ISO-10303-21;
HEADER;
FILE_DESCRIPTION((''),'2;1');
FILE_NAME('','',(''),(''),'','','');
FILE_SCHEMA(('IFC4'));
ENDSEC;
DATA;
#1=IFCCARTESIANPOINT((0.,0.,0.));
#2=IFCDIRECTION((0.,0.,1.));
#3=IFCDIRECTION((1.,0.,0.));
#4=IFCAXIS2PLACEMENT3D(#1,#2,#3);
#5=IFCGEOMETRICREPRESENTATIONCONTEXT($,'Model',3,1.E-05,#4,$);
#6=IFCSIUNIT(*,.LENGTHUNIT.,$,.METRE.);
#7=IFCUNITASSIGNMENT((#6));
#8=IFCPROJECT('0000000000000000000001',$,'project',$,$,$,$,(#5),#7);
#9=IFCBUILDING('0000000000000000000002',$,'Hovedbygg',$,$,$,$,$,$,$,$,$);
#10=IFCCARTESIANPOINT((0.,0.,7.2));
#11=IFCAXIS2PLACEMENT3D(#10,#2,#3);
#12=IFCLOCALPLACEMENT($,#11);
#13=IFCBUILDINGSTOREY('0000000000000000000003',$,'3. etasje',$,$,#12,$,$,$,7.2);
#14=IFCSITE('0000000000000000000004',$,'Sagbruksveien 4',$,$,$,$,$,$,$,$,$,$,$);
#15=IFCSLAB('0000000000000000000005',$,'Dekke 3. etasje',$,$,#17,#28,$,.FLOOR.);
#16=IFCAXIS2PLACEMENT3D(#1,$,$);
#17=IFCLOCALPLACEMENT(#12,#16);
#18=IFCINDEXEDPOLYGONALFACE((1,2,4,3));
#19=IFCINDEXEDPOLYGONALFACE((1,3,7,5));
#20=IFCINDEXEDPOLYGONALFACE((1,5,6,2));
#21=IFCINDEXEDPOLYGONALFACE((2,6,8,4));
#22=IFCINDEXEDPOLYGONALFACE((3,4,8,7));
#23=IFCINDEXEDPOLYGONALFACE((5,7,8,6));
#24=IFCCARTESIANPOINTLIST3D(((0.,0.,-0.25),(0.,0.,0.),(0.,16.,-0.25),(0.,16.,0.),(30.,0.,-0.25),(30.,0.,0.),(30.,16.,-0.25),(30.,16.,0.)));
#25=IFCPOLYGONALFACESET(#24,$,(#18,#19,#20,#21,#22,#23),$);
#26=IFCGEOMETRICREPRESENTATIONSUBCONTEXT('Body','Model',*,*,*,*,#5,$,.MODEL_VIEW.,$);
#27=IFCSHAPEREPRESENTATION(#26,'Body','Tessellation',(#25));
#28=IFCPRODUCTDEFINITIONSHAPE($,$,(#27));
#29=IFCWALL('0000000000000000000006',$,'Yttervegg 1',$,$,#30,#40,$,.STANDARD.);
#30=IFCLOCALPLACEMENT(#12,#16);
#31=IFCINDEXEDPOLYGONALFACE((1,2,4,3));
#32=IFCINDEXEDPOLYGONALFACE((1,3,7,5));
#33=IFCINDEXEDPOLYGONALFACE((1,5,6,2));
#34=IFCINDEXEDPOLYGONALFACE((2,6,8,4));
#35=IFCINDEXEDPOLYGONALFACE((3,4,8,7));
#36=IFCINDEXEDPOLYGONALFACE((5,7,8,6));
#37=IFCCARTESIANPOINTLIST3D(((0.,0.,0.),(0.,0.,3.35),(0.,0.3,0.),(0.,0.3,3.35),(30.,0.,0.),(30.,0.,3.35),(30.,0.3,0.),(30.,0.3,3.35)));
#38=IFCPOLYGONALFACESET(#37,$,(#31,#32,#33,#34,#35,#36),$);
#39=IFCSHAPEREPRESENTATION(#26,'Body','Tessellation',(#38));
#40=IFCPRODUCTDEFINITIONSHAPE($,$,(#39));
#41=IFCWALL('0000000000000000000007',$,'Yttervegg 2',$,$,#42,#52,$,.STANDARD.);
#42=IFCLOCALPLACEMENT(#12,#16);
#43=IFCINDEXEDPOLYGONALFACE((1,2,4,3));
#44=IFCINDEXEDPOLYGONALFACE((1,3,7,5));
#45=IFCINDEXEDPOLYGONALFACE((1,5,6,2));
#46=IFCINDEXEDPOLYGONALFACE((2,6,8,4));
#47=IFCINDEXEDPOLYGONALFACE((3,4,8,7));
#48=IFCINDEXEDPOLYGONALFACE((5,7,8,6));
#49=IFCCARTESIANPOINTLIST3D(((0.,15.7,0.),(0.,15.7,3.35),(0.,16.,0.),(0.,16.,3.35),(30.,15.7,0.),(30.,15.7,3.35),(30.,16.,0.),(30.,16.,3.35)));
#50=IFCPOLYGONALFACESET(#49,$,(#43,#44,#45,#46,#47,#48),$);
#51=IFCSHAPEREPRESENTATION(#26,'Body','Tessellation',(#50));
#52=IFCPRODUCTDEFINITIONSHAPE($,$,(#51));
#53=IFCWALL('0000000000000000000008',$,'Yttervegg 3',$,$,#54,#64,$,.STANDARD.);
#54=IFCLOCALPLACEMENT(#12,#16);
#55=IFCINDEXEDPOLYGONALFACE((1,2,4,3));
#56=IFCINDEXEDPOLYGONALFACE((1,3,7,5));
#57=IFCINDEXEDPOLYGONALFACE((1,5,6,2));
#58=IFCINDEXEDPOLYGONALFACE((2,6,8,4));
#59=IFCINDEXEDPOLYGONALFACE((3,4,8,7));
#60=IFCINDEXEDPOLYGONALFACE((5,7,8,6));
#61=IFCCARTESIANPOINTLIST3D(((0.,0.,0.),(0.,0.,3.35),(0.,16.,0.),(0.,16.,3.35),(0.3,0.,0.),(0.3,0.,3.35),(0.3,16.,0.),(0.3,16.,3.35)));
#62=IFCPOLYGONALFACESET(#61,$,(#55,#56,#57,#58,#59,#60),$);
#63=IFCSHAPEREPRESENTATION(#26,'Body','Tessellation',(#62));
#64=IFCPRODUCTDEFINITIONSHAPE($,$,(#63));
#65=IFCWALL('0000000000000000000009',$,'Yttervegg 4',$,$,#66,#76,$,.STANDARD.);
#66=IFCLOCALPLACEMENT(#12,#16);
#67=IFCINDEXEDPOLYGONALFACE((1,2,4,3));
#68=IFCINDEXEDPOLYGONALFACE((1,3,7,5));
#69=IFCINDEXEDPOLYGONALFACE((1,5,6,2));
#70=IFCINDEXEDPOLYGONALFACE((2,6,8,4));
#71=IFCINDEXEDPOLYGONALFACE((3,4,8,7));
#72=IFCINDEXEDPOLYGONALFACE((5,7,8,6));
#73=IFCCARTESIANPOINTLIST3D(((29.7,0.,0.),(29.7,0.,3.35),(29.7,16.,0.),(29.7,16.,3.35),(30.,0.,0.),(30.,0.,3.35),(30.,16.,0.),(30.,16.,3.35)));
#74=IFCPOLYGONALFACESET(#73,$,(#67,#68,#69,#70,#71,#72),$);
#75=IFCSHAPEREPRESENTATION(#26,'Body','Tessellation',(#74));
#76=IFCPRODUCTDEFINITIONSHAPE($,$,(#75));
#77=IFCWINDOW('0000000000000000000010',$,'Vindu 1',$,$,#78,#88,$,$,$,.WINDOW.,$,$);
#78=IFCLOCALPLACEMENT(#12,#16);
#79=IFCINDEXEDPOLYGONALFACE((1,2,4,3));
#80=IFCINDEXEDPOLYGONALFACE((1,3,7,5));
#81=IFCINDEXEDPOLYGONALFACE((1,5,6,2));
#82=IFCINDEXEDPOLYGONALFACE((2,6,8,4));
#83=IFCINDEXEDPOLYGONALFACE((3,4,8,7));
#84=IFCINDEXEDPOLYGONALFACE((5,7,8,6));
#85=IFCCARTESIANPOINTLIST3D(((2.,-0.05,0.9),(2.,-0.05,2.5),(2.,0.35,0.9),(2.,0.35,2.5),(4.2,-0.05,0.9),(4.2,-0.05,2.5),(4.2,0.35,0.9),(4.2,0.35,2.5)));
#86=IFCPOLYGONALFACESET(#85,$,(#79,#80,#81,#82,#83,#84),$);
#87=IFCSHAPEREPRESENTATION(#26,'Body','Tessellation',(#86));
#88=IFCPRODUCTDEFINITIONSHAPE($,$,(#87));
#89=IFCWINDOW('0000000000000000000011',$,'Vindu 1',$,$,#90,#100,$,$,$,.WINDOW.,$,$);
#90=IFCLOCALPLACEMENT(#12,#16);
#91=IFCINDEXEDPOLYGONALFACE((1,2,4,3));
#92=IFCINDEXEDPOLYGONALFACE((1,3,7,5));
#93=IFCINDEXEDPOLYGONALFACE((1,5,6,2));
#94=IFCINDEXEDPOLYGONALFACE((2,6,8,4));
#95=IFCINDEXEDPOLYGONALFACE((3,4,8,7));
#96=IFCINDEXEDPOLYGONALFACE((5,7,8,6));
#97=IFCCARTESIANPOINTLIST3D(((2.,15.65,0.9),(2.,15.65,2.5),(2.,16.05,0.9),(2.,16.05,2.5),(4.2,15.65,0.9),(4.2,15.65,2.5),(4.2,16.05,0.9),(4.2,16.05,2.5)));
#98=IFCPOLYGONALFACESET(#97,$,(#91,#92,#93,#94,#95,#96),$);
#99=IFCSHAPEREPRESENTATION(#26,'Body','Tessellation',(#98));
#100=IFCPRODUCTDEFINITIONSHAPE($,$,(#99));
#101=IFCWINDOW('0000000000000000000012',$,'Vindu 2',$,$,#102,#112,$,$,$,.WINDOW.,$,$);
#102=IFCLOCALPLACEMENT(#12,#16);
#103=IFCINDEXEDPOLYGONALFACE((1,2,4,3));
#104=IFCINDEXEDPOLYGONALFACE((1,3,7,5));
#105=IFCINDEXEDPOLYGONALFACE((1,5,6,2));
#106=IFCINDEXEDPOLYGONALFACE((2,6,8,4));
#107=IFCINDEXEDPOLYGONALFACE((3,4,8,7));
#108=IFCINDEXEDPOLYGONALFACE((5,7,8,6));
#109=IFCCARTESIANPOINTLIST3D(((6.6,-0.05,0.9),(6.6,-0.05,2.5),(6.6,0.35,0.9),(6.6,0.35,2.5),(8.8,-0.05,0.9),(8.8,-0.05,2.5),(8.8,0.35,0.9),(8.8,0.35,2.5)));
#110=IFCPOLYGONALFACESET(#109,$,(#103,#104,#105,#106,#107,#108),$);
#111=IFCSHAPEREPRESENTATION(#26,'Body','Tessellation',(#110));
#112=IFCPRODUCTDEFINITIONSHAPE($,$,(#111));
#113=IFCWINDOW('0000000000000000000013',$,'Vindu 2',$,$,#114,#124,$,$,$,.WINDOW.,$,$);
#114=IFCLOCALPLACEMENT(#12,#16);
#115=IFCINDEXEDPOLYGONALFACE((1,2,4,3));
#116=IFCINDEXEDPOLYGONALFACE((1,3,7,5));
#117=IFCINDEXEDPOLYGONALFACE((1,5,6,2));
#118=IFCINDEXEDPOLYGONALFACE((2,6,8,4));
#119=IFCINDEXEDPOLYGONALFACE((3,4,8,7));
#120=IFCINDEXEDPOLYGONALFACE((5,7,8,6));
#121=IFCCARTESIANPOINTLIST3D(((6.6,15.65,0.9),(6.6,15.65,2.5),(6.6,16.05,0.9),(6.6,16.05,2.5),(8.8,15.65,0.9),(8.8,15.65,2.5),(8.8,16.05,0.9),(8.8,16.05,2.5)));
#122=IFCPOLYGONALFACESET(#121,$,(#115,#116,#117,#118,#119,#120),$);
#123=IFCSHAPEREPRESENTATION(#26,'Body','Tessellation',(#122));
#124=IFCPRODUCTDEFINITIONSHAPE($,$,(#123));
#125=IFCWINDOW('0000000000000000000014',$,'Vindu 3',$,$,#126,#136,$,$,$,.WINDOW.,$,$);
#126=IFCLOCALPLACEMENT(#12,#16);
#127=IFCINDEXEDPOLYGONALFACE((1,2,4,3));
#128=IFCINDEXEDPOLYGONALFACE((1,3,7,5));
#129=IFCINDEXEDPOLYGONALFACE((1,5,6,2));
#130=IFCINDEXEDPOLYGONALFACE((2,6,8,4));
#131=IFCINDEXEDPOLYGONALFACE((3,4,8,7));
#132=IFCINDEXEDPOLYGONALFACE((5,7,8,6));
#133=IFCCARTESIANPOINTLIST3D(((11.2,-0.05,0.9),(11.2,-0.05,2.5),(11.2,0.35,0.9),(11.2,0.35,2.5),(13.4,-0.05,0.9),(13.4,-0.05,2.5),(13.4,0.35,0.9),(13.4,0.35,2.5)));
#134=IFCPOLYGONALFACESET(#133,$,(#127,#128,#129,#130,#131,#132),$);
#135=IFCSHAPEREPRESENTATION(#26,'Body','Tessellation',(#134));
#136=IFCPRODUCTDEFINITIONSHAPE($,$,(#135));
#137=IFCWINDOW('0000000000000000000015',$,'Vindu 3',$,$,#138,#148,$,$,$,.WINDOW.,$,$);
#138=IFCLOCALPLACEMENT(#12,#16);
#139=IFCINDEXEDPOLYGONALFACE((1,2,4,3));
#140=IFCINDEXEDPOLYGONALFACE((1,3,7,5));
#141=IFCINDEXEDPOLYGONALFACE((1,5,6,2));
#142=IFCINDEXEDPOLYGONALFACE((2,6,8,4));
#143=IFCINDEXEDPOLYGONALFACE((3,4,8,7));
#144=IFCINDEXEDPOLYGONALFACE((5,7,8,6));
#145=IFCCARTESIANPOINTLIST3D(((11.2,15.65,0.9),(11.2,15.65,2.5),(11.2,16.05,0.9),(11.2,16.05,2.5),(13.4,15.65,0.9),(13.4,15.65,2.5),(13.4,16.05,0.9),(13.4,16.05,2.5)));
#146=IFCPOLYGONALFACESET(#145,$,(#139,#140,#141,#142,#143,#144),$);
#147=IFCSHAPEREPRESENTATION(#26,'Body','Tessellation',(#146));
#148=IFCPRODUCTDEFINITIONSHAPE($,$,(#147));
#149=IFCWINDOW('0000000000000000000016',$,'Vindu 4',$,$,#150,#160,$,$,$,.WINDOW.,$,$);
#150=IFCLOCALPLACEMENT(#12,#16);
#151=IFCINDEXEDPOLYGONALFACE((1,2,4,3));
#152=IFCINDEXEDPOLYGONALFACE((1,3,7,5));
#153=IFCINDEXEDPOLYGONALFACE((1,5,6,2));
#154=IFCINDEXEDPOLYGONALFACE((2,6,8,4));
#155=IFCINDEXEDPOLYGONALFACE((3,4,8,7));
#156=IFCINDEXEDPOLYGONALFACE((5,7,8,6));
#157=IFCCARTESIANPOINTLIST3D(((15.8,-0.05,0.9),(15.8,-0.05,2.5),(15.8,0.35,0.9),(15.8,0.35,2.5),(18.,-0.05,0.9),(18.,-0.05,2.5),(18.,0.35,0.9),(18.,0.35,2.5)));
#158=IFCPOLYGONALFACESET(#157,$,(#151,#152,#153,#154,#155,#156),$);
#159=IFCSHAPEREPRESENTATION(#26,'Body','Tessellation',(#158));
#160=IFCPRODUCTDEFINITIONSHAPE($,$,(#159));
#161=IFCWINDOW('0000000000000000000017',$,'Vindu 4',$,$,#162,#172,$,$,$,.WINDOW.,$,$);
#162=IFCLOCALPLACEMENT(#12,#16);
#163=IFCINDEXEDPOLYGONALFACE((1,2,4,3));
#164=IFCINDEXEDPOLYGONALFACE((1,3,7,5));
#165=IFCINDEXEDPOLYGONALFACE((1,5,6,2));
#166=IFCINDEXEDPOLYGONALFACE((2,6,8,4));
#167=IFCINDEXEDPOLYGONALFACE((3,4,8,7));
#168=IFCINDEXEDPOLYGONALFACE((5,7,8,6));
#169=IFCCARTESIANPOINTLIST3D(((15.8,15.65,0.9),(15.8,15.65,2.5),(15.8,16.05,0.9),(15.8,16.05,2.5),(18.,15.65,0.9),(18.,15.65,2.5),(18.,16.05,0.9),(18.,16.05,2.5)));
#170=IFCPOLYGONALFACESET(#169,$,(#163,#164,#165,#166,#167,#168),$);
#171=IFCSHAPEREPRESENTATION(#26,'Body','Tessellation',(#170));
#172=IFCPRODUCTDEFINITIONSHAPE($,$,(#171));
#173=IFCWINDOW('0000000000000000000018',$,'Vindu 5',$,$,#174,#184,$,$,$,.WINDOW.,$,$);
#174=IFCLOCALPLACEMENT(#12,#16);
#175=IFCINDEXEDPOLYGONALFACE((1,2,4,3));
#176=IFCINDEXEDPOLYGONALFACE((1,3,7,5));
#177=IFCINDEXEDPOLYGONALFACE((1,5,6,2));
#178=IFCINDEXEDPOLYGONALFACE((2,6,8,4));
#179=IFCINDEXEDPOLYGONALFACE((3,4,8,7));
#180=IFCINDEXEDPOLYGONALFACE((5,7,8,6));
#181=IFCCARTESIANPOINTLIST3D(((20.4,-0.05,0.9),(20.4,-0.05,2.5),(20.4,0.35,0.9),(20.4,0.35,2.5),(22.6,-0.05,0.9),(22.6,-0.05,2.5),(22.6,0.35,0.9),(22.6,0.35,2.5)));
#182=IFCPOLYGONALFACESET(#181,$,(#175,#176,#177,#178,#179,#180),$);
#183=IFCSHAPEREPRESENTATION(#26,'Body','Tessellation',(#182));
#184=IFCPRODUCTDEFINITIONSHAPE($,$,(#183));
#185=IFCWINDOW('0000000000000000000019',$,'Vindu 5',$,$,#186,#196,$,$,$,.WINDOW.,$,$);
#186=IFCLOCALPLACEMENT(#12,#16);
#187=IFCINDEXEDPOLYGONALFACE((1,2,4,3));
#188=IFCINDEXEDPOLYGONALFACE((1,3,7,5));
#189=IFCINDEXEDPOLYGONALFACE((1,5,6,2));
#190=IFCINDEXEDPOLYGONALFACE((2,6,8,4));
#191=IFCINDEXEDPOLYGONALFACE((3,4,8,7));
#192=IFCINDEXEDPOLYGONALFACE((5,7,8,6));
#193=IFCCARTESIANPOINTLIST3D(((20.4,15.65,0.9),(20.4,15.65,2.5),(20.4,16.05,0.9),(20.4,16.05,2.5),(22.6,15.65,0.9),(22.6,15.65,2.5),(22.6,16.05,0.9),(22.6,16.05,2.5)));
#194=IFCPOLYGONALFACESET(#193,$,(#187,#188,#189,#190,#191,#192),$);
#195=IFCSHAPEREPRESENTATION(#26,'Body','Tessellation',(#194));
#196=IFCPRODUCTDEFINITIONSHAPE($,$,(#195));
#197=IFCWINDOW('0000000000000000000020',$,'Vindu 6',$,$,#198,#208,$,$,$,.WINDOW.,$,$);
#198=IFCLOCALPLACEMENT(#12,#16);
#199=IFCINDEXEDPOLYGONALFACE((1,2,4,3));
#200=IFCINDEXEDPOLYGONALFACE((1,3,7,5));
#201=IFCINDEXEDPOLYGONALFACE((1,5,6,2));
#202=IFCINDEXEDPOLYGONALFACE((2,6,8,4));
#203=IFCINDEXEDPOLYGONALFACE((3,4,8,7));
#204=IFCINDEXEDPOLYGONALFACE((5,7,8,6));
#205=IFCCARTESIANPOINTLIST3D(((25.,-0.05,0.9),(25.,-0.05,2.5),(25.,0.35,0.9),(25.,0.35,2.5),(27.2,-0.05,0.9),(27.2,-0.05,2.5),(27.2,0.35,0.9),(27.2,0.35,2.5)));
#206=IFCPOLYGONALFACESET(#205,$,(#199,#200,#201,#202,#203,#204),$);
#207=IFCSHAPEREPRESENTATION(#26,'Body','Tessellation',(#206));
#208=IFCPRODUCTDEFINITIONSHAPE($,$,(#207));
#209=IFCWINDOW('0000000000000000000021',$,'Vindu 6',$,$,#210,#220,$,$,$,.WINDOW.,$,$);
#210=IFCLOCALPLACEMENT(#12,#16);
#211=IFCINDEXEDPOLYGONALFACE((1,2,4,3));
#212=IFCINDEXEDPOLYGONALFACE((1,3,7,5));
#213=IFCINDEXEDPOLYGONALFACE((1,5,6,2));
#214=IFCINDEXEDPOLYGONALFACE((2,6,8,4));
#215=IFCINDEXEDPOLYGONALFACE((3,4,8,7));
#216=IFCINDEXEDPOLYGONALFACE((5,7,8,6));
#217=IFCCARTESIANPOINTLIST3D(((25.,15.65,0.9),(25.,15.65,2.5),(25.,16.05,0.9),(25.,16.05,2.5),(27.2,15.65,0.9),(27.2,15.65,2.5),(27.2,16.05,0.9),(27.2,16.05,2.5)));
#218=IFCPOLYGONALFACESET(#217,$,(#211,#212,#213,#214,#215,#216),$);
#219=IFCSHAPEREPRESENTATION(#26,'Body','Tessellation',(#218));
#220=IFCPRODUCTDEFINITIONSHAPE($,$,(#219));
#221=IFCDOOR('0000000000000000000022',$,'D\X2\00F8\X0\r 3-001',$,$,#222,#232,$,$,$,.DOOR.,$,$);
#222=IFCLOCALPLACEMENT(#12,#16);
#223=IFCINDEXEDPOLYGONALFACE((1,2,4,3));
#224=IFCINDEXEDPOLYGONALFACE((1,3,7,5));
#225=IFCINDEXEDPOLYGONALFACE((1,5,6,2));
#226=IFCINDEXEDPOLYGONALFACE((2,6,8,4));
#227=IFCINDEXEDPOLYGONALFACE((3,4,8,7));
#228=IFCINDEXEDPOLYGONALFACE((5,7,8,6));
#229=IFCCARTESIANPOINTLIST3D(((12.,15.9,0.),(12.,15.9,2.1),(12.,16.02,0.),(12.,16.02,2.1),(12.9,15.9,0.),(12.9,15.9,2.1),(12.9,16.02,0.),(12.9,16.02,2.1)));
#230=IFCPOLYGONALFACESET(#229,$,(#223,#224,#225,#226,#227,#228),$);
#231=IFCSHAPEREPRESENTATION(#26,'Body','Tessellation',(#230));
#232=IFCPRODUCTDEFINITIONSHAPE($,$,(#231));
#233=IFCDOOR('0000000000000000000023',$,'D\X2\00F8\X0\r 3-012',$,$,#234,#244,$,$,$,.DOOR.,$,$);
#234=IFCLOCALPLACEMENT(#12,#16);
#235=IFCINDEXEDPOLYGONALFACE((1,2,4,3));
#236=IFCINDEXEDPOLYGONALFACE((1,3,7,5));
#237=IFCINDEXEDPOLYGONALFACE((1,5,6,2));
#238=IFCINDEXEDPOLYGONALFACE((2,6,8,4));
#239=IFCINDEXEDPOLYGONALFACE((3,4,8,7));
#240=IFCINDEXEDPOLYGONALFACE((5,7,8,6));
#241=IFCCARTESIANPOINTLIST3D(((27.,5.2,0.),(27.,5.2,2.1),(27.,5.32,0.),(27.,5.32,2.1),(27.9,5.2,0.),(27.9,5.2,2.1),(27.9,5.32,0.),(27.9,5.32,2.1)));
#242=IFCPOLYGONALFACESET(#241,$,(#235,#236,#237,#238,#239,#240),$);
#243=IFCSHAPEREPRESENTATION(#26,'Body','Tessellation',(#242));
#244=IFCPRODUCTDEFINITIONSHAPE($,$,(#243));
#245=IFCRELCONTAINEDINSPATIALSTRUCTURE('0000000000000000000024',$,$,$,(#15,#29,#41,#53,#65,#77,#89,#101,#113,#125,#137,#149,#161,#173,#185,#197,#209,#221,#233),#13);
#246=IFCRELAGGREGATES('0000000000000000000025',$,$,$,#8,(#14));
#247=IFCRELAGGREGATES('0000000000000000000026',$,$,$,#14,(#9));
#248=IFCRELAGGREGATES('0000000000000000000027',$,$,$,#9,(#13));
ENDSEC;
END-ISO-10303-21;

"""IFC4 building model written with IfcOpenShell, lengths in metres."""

from ifc_helpers import new_model, si_unit, frame, origin_with_axes, place, context, subcontext, project, spatial, line, indexed_curve, outline, extrude, element, save


model = new_model("IFC4")

# Units and contexts
model_context = context("Model", 3, precision=1e-05, world=origin_with_axes())
body_context = subcontext(model_context, "Body", "Model", "MODEL_VIEW")
ifc_project = project(units=[si_unit("LENGTHUNIT", "METRE")], contexts=[model_context])

# Site, building, storey
site = spatial("IfcSite", under=ifc_project, Name="Sagbruksveien 4")
building = spatial("IfcBuilding", under=site, Name="Hovedbygg")
storey_placement = place(None, frame((0.0, 0.0, 7.2), z_axis=(0.0, 0.0, 1.0), x_axis=(1.0, 0.0, 0.0)))
storey = spatial("IfcBuildingStorey", under=building, at=storey_placement, Name="3. etasje", Elevation=7.2)

# Slab
slab_placement = place(storey_placement, frame((0.0, 0.0, -0.25), z_axis=(0.0, 0.0, 1.0), x_axis=(1.0, 0.0, 0.0)))
element("IfcSlab", 1, at=slab_placement, inside=storey, Name="Dekke 3. etasje", PredefinedType="FLOOR", context=body_context, shape_type="SweptSolid", body=[
    extrude(outline(indexed_curve([(0.0, 0.0), (30.0, 0.0), (30.0, 16.0), (0.0, 16.0)], segments=[line(1, 2, 3, 4, 1)])), origin_with_axes(), (0.0, 0.0, 1.0), 0.25),
])

# Walls
for number, where, z_axis, x_axis, name in (
    (2, (0.0, 0.0, 0.0), (0.0, 0.0, 1.0), (1.0, 0.0, 0.0), "Yttervegg 1"),
    (3, (0.0, 15.7, 0.0), (0.0, 0.0, 1.0), (1.0, 0.0, 0.0), "Yttervegg 2"),
):
    element("IfcWall", number, at=place(storey_placement, frame(where, z_axis=z_axis, x_axis=x_axis)), inside=storey, Name=name, PredefinedType="STANDARD", context=body_context, shape_type="SweptSolid", body=[
        extrude(outline(indexed_curve([(0.0, 0.0), (30.0, 0.0), (30.0, 0.3), (0.0, 0.3)], segments=[line(1, 2, 3, 4, 1)])), origin_with_axes(), (0.0, 0.0, 1.0), 3.35),
    ])
for number, where, z_axis, x_axis, name in (
    (4, (0.0, 0.0, 0.0), (0.0, 0.0, 1.0), (1.0, 0.0, 0.0), "Yttervegg 3"),
    (5, (29.7, 0.0, 0.0), (0.0, 0.0, 1.0), (1.0, 0.0, 0.0), "Yttervegg 4"),
):
    element("IfcWall", number, at=place(storey_placement, frame(where, z_axis=z_axis, x_axis=x_axis)), inside=storey, Name=name, PredefinedType="STANDARD", context=body_context, shape_type="SweptSolid", body=[
        extrude(outline(indexed_curve([(0.0, 0.0), (0.3, 0.0), (0.3, 16.0), (0.0, 16.0)], segments=[line(1, 2, 3, 4, 1)])), origin_with_axes(), (0.0, 0.0, 1.0), 3.35),
    ])

# Windows
for number, where, z_axis, x_axis, name in (
    (6, (2.0, -0.05, 0.9), (0.0, 0.0, 1.0), (1.0, 0.0, 0.0), "Vindu 1"),
    (7, (2.0, 15.65, 0.9), (0.0, 0.0, 1.0), (1.0, 0.0, 0.0), "Vindu 1"),
    (8, (6.6, -0.05, 0.9), (0.0, 0.0, 1.0), (1.0, 0.0, 0.0), "Vindu 2"),
    (9, (6.6, 15.65, 0.9), (0.0, 0.0, 1.0), (1.0, 0.0, 0.0), "Vindu 2"),
    (10, (11.2, -0.05, 0.9), (0.0, 0.0, 1.0), (1.0, 0.0, 0.0), "Vindu 3"),
    (11, (11.2, 15.65, 0.9), (0.0, 0.0, 1.0), (1.0, 0.0, 0.0), "Vindu 3"),
    (12, (15.8, -0.05, 0.9), (0.0, 0.0, 1.0), (1.0, 0.0, 0.0), "Vindu 4"),
    (13, (15.8, 15.65, 0.9), (0.0, 0.0, 1.0), (1.0, 0.0, 0.0), "Vindu 4"),
    (14, (20.4, -0.05, 0.9), (0.0, 0.0, 1.0), (1.0, 0.0, 0.0), "Vindu 5"),
    (15, (20.4, 15.65, 0.9), (0.0, 0.0, 1.0), (1.0, 0.0, 0.0), "Vindu 5"),
    (16, (25.0, -0.05, 0.9), (0.0, 0.0, 1.0), (1.0, 0.0, 0.0), "Vindu 6"),
    (17, (25.0, 15.65, 0.9), (0.0, 0.0, 1.0), (1.0, 0.0, 0.0), "Vindu 6"),
):
    element("IfcWindow", number, at=place(storey_placement, frame(where, z_axis=z_axis, x_axis=x_axis)), inside=storey, Name=name, PredefinedType="WINDOW", context=body_context, shape_type="SweptSolid", body=[
        extrude(outline(indexed_curve([(0.0, 0.0), (2.2, 0.0), (2.2, 0.4), (0.0, 0.4)], segments=[line(1, 2, 3, 4, 1)])), origin_with_axes(), (0.0, 0.0, 1.0), 1.6),
    ])

# Doors
for number, where, z_axis, x_axis, name in (
    (18, (12.0, 15.9, 0.0), (0.0, 0.0, 1.0), (1.0, 0.0, 0.0), "Dør 3-001"),
    (19, (27.0, 5.2, 0.0), (0.0, 0.0, 1.0), (1.0, 0.0, 0.0), "Dør 3-012"),
):
    element("IfcDoor", number, at=place(storey_placement, frame(where, z_axis=z_axis, x_axis=x_axis)), inside=storey, Name=name, PredefinedType="DOOR", context=body_context, shape_type="SweptSolid", body=[
        extrude(outline(indexed_curve([(0.0, 0.0), (0.9, 0.0), (0.9, 0.12), (0.0, 0.12)], segments=[line(1, 2, 3, 4, 1)])), origin_with_axes(), (0.0, 0.0, 1.0), 2.1),
    ])

save(model, "model.ifc")
